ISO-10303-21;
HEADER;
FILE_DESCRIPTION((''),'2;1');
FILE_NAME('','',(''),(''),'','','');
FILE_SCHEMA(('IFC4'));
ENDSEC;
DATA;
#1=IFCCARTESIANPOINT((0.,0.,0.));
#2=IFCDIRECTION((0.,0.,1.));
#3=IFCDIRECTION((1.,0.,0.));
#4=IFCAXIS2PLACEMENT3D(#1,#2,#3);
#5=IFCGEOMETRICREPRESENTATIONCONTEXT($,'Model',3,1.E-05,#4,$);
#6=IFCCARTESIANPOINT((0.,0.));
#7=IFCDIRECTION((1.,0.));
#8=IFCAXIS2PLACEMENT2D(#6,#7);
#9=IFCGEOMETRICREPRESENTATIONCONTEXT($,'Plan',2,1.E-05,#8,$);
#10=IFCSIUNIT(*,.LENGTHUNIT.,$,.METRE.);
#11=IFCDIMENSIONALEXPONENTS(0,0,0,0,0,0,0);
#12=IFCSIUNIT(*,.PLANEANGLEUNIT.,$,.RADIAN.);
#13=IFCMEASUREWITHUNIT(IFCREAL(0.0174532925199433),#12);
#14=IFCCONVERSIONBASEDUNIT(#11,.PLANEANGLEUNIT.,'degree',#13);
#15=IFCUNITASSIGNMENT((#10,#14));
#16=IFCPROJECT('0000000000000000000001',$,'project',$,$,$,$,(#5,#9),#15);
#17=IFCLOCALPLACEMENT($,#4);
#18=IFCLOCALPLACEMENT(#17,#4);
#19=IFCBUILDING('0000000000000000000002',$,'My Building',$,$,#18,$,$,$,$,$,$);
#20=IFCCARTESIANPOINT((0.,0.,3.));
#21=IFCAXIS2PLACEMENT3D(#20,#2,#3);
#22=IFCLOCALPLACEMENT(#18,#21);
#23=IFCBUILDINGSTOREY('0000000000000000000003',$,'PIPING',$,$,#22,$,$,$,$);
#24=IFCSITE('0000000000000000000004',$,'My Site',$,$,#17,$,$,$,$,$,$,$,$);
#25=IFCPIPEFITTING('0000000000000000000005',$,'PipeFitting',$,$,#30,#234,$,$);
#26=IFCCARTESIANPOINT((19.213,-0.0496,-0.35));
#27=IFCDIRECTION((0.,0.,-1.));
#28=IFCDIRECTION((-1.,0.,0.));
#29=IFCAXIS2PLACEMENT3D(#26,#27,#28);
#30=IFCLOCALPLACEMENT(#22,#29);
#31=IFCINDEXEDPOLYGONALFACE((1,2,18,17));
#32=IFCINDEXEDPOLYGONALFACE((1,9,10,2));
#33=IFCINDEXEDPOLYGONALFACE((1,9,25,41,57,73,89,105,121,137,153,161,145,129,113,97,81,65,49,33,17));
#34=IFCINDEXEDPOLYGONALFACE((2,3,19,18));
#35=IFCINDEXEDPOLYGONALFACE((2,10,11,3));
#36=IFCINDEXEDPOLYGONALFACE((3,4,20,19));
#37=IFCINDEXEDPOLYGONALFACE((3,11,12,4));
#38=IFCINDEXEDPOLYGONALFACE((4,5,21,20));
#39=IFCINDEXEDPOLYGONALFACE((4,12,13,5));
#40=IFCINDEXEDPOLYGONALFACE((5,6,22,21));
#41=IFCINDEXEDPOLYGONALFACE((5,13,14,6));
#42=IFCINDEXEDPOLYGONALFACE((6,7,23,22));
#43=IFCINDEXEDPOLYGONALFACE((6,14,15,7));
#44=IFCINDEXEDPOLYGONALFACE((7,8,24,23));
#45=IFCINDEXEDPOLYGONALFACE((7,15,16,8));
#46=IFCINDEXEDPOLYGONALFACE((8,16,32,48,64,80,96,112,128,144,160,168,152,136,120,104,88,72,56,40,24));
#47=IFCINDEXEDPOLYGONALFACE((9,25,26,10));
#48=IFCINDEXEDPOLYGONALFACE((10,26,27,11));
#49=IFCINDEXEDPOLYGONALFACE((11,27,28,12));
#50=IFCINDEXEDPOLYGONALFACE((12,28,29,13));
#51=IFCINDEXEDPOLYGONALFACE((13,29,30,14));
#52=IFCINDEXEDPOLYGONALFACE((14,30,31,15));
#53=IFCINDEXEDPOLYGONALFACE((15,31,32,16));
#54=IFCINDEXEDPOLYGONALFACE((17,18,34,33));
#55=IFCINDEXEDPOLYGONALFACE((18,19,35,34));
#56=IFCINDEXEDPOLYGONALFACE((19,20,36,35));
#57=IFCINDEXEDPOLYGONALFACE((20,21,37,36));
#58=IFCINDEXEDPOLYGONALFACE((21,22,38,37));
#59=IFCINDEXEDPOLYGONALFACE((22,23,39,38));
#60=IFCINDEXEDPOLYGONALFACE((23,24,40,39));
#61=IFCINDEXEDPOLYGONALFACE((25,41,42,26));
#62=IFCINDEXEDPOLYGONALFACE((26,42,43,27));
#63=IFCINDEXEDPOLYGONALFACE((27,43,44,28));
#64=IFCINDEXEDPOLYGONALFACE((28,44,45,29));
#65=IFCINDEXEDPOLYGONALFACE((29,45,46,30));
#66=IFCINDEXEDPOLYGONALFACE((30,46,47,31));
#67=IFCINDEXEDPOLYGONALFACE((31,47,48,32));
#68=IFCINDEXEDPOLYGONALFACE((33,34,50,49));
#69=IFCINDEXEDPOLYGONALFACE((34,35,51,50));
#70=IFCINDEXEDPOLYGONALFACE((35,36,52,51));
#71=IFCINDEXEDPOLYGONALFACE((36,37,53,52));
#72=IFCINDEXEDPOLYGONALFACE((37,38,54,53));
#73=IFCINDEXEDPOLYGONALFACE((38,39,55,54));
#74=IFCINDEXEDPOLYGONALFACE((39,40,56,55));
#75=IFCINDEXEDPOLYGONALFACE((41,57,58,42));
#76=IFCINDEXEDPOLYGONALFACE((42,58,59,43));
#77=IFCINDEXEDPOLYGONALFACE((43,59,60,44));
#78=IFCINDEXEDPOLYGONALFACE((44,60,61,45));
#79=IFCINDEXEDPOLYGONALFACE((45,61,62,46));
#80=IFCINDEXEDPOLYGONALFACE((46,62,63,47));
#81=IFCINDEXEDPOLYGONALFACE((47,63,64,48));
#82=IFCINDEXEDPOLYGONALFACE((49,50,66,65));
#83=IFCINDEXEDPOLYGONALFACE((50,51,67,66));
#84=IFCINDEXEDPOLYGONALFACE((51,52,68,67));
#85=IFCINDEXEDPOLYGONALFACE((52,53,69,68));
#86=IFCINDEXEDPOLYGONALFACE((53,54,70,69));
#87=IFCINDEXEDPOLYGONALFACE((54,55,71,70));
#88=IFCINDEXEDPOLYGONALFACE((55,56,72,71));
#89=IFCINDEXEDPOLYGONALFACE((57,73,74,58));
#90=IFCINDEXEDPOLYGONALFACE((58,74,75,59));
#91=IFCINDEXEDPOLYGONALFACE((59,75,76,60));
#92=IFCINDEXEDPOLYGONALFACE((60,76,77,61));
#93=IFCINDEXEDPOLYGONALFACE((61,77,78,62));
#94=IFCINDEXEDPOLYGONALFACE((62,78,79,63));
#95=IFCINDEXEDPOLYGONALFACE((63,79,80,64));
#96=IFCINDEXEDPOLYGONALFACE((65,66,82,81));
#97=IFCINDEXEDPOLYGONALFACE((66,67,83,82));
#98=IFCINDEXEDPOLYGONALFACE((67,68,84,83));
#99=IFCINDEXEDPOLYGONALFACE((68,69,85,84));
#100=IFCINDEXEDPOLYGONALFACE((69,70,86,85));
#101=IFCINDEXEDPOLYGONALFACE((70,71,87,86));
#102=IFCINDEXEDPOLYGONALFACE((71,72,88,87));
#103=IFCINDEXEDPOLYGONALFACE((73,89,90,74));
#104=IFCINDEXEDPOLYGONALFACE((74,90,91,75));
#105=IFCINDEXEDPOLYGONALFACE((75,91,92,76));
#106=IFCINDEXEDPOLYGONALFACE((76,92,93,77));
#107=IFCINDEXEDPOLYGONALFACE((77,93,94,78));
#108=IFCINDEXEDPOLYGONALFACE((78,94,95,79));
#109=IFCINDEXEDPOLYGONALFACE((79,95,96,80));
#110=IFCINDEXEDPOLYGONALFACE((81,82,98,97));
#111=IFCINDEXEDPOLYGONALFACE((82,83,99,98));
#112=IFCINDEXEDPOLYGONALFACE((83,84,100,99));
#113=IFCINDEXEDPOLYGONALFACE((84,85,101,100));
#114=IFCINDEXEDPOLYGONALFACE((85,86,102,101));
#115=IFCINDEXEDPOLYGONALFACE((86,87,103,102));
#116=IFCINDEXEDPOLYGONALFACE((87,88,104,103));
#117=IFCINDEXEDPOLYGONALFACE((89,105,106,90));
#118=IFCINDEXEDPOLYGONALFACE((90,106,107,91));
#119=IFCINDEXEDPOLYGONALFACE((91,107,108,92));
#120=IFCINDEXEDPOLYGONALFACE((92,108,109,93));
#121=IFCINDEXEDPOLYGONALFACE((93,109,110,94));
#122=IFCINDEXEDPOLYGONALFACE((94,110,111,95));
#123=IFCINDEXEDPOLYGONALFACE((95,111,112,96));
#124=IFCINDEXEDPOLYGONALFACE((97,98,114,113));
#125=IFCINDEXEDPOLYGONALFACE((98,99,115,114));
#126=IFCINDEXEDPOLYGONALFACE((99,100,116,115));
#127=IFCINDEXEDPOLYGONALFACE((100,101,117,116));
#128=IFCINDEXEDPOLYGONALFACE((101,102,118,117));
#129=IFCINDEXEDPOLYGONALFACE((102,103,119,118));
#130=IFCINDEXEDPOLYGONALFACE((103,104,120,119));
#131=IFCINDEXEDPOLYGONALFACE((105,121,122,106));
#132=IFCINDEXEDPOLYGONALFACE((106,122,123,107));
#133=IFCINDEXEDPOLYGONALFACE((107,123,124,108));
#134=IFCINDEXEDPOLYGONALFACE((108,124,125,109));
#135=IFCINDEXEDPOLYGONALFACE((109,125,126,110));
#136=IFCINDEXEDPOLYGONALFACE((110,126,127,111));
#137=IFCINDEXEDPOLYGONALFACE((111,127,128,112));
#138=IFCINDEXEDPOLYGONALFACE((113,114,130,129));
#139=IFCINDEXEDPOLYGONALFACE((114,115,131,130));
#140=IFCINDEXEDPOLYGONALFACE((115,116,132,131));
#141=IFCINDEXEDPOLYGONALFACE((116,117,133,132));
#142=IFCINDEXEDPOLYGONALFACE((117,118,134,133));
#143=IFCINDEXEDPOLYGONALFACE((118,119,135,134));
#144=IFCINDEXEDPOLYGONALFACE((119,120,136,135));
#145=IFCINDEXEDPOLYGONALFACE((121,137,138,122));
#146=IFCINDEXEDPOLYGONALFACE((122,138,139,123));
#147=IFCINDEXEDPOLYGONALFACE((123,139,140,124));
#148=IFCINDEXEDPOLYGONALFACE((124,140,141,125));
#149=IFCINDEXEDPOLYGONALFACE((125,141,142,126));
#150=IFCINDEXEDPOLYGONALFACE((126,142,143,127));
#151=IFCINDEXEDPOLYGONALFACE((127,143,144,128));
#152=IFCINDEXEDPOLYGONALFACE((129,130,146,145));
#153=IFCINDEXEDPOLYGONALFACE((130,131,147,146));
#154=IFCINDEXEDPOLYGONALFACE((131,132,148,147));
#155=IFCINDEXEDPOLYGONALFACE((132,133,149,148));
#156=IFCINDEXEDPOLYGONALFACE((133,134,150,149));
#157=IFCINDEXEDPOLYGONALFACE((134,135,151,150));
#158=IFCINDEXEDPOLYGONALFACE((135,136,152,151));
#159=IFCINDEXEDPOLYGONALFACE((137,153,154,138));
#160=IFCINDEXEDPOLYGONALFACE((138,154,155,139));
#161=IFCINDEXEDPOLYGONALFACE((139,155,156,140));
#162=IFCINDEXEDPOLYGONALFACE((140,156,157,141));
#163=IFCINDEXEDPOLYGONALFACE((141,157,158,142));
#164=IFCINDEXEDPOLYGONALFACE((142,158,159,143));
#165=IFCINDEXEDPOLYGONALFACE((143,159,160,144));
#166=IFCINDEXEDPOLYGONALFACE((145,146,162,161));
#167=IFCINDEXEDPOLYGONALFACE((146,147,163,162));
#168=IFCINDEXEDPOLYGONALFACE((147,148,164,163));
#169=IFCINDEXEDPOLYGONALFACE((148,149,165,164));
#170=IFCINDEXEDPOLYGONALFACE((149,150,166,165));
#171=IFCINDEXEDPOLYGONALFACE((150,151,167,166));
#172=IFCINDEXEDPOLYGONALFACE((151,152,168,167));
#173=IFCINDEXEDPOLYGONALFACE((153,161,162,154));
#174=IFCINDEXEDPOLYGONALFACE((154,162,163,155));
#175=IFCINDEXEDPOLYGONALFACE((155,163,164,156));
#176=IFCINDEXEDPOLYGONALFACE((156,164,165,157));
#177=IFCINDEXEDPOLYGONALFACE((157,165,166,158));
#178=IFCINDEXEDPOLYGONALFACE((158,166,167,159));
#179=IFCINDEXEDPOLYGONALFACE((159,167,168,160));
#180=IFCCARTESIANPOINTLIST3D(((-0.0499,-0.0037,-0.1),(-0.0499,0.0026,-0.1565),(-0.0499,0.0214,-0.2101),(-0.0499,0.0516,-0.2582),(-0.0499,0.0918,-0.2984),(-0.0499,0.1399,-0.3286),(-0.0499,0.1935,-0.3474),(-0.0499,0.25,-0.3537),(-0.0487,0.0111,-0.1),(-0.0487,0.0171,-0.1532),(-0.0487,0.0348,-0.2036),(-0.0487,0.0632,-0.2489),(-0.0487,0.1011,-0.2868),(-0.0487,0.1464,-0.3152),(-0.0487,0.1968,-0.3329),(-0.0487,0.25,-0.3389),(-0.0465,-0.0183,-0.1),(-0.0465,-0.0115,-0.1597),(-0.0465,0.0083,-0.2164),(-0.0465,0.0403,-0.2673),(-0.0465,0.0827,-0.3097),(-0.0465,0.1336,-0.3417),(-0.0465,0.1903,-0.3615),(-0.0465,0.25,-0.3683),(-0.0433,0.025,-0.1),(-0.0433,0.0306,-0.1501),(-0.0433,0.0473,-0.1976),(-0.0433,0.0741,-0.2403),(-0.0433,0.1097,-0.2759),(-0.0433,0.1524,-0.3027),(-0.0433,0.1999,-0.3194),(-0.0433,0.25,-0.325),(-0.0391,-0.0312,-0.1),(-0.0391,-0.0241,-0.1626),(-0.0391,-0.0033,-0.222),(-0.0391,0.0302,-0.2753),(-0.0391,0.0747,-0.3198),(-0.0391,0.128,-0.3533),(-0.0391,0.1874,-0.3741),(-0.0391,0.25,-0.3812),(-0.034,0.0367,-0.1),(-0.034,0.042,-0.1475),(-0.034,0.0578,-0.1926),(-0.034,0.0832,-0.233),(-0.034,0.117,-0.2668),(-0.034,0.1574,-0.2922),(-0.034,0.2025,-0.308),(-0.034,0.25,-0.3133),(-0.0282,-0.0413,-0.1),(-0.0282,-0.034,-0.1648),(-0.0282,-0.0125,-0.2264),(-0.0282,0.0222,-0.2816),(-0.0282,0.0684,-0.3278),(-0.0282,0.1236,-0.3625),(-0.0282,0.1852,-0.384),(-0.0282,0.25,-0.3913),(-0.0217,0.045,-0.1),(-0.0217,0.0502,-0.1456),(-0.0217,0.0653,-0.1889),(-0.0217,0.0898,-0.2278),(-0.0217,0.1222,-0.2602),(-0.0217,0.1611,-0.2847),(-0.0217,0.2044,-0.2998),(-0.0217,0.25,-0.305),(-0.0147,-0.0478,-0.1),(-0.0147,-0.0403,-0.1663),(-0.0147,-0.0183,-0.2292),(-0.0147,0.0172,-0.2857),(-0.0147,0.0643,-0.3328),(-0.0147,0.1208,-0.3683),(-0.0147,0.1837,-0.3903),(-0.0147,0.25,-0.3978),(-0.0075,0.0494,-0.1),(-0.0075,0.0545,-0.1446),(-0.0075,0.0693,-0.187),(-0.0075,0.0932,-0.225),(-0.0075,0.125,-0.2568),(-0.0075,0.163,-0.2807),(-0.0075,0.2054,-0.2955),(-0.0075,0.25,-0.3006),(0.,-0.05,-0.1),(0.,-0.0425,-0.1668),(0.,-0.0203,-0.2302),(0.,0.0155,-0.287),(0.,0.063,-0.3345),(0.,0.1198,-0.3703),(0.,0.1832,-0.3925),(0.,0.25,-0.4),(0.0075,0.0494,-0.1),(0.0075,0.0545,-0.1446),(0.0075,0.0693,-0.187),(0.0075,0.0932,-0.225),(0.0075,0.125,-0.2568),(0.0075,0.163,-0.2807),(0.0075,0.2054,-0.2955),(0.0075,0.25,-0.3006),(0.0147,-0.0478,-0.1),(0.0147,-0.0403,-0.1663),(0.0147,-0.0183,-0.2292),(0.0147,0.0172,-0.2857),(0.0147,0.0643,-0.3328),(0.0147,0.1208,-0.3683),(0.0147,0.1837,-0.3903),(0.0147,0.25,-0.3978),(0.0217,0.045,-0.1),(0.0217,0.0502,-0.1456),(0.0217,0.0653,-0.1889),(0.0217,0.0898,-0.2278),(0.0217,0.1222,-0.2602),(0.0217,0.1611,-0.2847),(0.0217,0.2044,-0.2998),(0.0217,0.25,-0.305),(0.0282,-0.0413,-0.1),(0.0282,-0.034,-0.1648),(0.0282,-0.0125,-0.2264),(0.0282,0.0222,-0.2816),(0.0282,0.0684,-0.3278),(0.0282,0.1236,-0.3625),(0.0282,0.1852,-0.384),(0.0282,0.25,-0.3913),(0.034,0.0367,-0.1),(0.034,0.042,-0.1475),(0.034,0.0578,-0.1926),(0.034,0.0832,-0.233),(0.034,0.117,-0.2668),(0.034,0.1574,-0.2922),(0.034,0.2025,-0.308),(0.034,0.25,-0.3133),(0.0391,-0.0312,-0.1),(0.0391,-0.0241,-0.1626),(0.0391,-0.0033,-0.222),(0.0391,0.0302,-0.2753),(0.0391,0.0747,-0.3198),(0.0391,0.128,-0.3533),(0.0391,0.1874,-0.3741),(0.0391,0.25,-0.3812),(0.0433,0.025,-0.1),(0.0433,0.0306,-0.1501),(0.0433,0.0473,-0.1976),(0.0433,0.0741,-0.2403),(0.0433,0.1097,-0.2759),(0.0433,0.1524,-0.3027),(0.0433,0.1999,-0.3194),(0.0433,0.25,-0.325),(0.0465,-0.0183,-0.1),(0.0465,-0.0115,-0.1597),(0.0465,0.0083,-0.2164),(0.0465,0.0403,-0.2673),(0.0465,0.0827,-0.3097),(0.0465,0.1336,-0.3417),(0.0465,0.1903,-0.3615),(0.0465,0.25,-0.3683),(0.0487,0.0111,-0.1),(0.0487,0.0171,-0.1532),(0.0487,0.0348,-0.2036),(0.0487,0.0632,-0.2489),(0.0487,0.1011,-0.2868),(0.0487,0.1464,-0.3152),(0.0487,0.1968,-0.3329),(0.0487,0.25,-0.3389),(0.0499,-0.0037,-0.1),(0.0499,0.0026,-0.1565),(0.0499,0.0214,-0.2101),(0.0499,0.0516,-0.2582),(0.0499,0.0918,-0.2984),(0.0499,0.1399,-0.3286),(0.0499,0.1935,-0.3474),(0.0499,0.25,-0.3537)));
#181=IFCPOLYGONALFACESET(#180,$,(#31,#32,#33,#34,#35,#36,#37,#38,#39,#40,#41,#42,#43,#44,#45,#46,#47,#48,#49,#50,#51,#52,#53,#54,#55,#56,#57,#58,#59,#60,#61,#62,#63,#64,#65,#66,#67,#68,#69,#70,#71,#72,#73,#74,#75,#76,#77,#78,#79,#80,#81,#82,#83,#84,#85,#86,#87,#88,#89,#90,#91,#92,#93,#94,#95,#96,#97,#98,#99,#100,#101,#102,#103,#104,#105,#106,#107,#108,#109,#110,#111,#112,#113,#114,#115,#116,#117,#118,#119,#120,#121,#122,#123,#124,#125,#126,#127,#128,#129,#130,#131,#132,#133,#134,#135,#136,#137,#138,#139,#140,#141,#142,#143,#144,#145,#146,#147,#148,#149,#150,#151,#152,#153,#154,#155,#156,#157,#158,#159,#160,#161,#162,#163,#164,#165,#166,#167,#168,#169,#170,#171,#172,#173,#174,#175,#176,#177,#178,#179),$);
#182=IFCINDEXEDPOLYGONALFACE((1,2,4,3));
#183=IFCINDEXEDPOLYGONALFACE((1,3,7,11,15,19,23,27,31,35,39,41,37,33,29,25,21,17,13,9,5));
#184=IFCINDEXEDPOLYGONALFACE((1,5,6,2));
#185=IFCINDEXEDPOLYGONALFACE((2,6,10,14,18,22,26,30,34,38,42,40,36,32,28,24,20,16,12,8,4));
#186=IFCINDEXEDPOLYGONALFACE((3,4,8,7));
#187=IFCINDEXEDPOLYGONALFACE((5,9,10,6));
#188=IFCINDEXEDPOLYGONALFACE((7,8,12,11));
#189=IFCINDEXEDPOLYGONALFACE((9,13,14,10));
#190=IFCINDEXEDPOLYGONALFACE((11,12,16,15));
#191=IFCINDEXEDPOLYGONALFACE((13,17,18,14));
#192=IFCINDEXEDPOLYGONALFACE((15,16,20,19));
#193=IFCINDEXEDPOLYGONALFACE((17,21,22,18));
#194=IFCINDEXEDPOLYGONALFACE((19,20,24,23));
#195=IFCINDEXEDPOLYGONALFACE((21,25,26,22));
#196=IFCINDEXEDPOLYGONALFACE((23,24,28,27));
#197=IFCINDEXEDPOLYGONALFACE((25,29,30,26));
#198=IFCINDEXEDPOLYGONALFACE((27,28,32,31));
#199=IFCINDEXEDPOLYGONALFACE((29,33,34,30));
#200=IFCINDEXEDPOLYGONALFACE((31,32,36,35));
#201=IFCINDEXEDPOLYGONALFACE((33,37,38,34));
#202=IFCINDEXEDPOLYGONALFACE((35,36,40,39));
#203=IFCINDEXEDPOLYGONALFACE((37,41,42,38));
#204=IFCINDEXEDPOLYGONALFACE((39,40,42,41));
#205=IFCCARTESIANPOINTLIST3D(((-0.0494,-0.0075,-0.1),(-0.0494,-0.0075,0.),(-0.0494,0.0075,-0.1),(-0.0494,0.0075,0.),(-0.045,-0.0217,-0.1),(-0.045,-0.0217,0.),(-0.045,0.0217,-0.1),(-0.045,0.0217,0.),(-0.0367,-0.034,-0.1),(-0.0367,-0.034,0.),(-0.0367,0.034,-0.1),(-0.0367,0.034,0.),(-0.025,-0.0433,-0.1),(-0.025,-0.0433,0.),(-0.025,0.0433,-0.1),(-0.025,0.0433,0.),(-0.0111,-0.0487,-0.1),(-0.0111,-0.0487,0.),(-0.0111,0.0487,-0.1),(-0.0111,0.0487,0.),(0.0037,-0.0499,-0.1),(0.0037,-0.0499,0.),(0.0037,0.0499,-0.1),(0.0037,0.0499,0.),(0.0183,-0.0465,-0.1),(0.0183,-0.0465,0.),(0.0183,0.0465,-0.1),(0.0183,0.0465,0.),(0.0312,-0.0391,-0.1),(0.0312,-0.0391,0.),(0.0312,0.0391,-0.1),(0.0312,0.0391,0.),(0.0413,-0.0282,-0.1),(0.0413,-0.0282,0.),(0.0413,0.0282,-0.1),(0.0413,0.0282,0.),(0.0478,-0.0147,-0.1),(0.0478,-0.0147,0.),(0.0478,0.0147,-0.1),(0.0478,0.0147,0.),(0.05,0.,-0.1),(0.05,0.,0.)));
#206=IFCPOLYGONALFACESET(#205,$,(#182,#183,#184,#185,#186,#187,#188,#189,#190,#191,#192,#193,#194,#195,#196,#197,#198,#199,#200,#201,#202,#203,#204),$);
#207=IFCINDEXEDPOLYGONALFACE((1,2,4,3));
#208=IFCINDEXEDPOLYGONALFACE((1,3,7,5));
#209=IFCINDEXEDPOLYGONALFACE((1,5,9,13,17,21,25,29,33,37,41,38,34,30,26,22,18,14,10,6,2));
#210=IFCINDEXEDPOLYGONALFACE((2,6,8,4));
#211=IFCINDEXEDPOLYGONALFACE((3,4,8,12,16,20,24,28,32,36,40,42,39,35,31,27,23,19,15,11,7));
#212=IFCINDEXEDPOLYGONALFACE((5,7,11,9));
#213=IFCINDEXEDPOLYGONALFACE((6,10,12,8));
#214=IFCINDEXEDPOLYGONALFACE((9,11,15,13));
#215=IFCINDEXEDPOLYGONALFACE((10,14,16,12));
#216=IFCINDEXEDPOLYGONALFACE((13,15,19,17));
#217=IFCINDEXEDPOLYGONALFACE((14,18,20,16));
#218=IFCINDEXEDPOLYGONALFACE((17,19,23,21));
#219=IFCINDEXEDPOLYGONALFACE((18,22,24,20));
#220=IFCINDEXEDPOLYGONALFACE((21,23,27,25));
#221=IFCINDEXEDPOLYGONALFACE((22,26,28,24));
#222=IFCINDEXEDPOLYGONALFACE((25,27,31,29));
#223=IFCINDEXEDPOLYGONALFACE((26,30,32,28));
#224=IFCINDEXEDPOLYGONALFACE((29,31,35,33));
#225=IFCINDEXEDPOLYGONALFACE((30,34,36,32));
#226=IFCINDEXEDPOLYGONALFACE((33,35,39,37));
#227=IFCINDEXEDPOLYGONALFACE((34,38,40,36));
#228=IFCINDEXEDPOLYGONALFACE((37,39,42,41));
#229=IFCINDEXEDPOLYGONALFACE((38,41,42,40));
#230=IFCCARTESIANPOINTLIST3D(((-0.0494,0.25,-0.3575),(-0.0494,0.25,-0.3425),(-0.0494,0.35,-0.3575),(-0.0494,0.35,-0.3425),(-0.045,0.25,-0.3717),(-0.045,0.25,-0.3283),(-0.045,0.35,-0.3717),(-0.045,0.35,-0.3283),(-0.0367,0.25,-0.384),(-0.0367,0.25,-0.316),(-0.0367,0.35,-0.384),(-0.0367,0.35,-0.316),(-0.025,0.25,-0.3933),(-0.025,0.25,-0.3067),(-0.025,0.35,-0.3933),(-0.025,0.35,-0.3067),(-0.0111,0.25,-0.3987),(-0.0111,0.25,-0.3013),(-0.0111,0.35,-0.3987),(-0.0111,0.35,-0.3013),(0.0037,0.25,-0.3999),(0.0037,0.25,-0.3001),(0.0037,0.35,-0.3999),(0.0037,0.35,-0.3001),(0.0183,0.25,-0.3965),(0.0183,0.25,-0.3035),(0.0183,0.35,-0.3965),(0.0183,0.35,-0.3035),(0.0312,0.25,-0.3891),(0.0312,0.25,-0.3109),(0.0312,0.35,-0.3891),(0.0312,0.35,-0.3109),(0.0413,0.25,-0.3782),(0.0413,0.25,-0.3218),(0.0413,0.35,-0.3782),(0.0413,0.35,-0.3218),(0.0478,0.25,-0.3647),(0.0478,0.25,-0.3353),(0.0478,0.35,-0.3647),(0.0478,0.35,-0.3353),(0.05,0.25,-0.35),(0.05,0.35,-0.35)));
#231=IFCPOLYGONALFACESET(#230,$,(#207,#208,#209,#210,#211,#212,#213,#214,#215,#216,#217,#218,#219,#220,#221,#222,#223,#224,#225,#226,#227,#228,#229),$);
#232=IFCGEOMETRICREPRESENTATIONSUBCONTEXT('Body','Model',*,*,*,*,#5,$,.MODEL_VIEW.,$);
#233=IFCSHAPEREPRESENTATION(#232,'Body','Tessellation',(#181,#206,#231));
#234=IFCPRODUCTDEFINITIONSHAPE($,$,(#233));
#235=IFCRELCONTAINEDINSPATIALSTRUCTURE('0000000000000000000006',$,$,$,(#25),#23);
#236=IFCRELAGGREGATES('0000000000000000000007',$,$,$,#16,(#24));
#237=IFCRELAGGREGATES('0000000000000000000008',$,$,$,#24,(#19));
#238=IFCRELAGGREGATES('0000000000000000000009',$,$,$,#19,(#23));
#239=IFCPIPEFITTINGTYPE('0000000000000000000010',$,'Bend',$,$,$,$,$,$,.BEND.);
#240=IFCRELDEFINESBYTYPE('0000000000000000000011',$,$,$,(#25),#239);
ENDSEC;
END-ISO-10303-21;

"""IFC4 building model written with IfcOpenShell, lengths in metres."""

from ifc_helpers import new_model, entity, si_unit, converted_unit, frame, origin_with_axes, origin_2d_with_axis, place, context, subcontext, project, spatial, line, indexed_curve, circle, outline, extrude, source, transform, mapped, type_object, type_shapes, element, save


model = new_model("IFC4")

# Units and contexts
model_context = context("Model", 3, precision=1e-05, world=origin_with_axes())
plan_context = context("Plan", 2, precision=1e-05, world=origin_2d_with_axis())
body_context = subcontext(model_context, "Body", "Model", "MODEL_VIEW")
ifc_project = project(units=[si_unit("LENGTHUNIT", "METRE"), converted_unit("PLANEANGLEUNIT", "degree", entity("IfcReal", 0.0174532925199433), si_unit("PLANEANGLEUNIT", "RADIAN"), dimensions=[0, 0, 0, 0, 0, 0, 0])], contexts=[model_context, plan_context])

# Site, building, storey
site_placement = place(None, origin_with_axes())
site = spatial("IfcSite", under=ifc_project, at=site_placement, Name="My Site")
building_placement = place(site_placement, origin_with_axes())
building = spatial("IfcBuilding", under=site, at=building_placement, Name="My Building")
storey_placement = place(building_placement, frame((0.0, 0.0, 3.0), z_axis=(0.0, 0.0, 1.0), x_axis=(1.0, 0.0, 0.0)))
storey = spatial("IfcBuildingStorey", under=building, at=storey_placement, Name="PIPING")

# Shared definitions
pipe_fitting_type_1 = type_object("IfcPipeFittingType", Name="Bend", PredefinedType="BEND")
shared_shape = source(origin_with_axes(), body_context, "Body", "SolidModel", [
    entity("IfcSweptDiskSolid", entity("IfcIndexedPolyCurve", entity("IfcCartesianPointList3D", [[0.0, 0.0, -0.1], [0.0, 0.0732, -0.2768], [0.0, 0.25, -0.35]]), [entity("IfcArcIndex", [1, 2, 3])]), 0.05),
    extrude(circle(Radius=0.05), origin_with_axes(), (0.0, 0.0, -1.0), 0.1),
    extrude(circle(Radius=0.05), frame((0.0, 0.25, -0.35), z_axis=(0.0, 1.0, 0.0), x_axis=(1.0, 0.0, 0.0)), (0.0, 0.0, 1.0), 0.1),
])
type_shapes(pipe_fitting_type_1, [shared_shape])

# Pipe fitting, opening
pipe_fitting_1_placement = place(storey_placement, frame((19.213, -0.0496, -0.35), z_axis=(0.0, 0.0, -1.0), x_axis=(-1.0, 0.0, 0.0)))
pipe_fitting_1 = element("IfcPipeFitting", 1, at=pipe_fitting_1_placement, inside=storey, type_object=pipe_fitting_type_1, Name="PipeFitting", context=body_context, shape_type="MappedRepresentation", body=[
    mapped(shared_shape, transform((0.0, 0.0, 0.0), x_axis=(1.0, 0.0, 0.0), y_axis=(0.0, 1.0, 0.0), z_axis=(0.0, 0.0, 1.0), scale=1.0)),
])
opening_1_placement = place(pipe_fitting_1_placement, frame((19.213, 0.0496, 2.65), z_axis=(0.0, 0.0, -1.0), x_axis=(-1.0, 0.0, 0.0)))
element("IfcOpeningElement", 2, at=opening_1_placement, cuts=pipe_fitting_1, PredefinedType="OPENING", context=body_context, shape_type="SweptSolid", body=[
    extrude(outline(indexed_curve([(0.0, 0.0), (0.5, 0.0), (0.5, 0.5), (0.0, 0.5)], segments=[line(1, 2, 3, 4, 1)])), origin_with_axes(), (0.0, 0.0, 1.0), 0.5),
])

save(model, "model.ifc")
